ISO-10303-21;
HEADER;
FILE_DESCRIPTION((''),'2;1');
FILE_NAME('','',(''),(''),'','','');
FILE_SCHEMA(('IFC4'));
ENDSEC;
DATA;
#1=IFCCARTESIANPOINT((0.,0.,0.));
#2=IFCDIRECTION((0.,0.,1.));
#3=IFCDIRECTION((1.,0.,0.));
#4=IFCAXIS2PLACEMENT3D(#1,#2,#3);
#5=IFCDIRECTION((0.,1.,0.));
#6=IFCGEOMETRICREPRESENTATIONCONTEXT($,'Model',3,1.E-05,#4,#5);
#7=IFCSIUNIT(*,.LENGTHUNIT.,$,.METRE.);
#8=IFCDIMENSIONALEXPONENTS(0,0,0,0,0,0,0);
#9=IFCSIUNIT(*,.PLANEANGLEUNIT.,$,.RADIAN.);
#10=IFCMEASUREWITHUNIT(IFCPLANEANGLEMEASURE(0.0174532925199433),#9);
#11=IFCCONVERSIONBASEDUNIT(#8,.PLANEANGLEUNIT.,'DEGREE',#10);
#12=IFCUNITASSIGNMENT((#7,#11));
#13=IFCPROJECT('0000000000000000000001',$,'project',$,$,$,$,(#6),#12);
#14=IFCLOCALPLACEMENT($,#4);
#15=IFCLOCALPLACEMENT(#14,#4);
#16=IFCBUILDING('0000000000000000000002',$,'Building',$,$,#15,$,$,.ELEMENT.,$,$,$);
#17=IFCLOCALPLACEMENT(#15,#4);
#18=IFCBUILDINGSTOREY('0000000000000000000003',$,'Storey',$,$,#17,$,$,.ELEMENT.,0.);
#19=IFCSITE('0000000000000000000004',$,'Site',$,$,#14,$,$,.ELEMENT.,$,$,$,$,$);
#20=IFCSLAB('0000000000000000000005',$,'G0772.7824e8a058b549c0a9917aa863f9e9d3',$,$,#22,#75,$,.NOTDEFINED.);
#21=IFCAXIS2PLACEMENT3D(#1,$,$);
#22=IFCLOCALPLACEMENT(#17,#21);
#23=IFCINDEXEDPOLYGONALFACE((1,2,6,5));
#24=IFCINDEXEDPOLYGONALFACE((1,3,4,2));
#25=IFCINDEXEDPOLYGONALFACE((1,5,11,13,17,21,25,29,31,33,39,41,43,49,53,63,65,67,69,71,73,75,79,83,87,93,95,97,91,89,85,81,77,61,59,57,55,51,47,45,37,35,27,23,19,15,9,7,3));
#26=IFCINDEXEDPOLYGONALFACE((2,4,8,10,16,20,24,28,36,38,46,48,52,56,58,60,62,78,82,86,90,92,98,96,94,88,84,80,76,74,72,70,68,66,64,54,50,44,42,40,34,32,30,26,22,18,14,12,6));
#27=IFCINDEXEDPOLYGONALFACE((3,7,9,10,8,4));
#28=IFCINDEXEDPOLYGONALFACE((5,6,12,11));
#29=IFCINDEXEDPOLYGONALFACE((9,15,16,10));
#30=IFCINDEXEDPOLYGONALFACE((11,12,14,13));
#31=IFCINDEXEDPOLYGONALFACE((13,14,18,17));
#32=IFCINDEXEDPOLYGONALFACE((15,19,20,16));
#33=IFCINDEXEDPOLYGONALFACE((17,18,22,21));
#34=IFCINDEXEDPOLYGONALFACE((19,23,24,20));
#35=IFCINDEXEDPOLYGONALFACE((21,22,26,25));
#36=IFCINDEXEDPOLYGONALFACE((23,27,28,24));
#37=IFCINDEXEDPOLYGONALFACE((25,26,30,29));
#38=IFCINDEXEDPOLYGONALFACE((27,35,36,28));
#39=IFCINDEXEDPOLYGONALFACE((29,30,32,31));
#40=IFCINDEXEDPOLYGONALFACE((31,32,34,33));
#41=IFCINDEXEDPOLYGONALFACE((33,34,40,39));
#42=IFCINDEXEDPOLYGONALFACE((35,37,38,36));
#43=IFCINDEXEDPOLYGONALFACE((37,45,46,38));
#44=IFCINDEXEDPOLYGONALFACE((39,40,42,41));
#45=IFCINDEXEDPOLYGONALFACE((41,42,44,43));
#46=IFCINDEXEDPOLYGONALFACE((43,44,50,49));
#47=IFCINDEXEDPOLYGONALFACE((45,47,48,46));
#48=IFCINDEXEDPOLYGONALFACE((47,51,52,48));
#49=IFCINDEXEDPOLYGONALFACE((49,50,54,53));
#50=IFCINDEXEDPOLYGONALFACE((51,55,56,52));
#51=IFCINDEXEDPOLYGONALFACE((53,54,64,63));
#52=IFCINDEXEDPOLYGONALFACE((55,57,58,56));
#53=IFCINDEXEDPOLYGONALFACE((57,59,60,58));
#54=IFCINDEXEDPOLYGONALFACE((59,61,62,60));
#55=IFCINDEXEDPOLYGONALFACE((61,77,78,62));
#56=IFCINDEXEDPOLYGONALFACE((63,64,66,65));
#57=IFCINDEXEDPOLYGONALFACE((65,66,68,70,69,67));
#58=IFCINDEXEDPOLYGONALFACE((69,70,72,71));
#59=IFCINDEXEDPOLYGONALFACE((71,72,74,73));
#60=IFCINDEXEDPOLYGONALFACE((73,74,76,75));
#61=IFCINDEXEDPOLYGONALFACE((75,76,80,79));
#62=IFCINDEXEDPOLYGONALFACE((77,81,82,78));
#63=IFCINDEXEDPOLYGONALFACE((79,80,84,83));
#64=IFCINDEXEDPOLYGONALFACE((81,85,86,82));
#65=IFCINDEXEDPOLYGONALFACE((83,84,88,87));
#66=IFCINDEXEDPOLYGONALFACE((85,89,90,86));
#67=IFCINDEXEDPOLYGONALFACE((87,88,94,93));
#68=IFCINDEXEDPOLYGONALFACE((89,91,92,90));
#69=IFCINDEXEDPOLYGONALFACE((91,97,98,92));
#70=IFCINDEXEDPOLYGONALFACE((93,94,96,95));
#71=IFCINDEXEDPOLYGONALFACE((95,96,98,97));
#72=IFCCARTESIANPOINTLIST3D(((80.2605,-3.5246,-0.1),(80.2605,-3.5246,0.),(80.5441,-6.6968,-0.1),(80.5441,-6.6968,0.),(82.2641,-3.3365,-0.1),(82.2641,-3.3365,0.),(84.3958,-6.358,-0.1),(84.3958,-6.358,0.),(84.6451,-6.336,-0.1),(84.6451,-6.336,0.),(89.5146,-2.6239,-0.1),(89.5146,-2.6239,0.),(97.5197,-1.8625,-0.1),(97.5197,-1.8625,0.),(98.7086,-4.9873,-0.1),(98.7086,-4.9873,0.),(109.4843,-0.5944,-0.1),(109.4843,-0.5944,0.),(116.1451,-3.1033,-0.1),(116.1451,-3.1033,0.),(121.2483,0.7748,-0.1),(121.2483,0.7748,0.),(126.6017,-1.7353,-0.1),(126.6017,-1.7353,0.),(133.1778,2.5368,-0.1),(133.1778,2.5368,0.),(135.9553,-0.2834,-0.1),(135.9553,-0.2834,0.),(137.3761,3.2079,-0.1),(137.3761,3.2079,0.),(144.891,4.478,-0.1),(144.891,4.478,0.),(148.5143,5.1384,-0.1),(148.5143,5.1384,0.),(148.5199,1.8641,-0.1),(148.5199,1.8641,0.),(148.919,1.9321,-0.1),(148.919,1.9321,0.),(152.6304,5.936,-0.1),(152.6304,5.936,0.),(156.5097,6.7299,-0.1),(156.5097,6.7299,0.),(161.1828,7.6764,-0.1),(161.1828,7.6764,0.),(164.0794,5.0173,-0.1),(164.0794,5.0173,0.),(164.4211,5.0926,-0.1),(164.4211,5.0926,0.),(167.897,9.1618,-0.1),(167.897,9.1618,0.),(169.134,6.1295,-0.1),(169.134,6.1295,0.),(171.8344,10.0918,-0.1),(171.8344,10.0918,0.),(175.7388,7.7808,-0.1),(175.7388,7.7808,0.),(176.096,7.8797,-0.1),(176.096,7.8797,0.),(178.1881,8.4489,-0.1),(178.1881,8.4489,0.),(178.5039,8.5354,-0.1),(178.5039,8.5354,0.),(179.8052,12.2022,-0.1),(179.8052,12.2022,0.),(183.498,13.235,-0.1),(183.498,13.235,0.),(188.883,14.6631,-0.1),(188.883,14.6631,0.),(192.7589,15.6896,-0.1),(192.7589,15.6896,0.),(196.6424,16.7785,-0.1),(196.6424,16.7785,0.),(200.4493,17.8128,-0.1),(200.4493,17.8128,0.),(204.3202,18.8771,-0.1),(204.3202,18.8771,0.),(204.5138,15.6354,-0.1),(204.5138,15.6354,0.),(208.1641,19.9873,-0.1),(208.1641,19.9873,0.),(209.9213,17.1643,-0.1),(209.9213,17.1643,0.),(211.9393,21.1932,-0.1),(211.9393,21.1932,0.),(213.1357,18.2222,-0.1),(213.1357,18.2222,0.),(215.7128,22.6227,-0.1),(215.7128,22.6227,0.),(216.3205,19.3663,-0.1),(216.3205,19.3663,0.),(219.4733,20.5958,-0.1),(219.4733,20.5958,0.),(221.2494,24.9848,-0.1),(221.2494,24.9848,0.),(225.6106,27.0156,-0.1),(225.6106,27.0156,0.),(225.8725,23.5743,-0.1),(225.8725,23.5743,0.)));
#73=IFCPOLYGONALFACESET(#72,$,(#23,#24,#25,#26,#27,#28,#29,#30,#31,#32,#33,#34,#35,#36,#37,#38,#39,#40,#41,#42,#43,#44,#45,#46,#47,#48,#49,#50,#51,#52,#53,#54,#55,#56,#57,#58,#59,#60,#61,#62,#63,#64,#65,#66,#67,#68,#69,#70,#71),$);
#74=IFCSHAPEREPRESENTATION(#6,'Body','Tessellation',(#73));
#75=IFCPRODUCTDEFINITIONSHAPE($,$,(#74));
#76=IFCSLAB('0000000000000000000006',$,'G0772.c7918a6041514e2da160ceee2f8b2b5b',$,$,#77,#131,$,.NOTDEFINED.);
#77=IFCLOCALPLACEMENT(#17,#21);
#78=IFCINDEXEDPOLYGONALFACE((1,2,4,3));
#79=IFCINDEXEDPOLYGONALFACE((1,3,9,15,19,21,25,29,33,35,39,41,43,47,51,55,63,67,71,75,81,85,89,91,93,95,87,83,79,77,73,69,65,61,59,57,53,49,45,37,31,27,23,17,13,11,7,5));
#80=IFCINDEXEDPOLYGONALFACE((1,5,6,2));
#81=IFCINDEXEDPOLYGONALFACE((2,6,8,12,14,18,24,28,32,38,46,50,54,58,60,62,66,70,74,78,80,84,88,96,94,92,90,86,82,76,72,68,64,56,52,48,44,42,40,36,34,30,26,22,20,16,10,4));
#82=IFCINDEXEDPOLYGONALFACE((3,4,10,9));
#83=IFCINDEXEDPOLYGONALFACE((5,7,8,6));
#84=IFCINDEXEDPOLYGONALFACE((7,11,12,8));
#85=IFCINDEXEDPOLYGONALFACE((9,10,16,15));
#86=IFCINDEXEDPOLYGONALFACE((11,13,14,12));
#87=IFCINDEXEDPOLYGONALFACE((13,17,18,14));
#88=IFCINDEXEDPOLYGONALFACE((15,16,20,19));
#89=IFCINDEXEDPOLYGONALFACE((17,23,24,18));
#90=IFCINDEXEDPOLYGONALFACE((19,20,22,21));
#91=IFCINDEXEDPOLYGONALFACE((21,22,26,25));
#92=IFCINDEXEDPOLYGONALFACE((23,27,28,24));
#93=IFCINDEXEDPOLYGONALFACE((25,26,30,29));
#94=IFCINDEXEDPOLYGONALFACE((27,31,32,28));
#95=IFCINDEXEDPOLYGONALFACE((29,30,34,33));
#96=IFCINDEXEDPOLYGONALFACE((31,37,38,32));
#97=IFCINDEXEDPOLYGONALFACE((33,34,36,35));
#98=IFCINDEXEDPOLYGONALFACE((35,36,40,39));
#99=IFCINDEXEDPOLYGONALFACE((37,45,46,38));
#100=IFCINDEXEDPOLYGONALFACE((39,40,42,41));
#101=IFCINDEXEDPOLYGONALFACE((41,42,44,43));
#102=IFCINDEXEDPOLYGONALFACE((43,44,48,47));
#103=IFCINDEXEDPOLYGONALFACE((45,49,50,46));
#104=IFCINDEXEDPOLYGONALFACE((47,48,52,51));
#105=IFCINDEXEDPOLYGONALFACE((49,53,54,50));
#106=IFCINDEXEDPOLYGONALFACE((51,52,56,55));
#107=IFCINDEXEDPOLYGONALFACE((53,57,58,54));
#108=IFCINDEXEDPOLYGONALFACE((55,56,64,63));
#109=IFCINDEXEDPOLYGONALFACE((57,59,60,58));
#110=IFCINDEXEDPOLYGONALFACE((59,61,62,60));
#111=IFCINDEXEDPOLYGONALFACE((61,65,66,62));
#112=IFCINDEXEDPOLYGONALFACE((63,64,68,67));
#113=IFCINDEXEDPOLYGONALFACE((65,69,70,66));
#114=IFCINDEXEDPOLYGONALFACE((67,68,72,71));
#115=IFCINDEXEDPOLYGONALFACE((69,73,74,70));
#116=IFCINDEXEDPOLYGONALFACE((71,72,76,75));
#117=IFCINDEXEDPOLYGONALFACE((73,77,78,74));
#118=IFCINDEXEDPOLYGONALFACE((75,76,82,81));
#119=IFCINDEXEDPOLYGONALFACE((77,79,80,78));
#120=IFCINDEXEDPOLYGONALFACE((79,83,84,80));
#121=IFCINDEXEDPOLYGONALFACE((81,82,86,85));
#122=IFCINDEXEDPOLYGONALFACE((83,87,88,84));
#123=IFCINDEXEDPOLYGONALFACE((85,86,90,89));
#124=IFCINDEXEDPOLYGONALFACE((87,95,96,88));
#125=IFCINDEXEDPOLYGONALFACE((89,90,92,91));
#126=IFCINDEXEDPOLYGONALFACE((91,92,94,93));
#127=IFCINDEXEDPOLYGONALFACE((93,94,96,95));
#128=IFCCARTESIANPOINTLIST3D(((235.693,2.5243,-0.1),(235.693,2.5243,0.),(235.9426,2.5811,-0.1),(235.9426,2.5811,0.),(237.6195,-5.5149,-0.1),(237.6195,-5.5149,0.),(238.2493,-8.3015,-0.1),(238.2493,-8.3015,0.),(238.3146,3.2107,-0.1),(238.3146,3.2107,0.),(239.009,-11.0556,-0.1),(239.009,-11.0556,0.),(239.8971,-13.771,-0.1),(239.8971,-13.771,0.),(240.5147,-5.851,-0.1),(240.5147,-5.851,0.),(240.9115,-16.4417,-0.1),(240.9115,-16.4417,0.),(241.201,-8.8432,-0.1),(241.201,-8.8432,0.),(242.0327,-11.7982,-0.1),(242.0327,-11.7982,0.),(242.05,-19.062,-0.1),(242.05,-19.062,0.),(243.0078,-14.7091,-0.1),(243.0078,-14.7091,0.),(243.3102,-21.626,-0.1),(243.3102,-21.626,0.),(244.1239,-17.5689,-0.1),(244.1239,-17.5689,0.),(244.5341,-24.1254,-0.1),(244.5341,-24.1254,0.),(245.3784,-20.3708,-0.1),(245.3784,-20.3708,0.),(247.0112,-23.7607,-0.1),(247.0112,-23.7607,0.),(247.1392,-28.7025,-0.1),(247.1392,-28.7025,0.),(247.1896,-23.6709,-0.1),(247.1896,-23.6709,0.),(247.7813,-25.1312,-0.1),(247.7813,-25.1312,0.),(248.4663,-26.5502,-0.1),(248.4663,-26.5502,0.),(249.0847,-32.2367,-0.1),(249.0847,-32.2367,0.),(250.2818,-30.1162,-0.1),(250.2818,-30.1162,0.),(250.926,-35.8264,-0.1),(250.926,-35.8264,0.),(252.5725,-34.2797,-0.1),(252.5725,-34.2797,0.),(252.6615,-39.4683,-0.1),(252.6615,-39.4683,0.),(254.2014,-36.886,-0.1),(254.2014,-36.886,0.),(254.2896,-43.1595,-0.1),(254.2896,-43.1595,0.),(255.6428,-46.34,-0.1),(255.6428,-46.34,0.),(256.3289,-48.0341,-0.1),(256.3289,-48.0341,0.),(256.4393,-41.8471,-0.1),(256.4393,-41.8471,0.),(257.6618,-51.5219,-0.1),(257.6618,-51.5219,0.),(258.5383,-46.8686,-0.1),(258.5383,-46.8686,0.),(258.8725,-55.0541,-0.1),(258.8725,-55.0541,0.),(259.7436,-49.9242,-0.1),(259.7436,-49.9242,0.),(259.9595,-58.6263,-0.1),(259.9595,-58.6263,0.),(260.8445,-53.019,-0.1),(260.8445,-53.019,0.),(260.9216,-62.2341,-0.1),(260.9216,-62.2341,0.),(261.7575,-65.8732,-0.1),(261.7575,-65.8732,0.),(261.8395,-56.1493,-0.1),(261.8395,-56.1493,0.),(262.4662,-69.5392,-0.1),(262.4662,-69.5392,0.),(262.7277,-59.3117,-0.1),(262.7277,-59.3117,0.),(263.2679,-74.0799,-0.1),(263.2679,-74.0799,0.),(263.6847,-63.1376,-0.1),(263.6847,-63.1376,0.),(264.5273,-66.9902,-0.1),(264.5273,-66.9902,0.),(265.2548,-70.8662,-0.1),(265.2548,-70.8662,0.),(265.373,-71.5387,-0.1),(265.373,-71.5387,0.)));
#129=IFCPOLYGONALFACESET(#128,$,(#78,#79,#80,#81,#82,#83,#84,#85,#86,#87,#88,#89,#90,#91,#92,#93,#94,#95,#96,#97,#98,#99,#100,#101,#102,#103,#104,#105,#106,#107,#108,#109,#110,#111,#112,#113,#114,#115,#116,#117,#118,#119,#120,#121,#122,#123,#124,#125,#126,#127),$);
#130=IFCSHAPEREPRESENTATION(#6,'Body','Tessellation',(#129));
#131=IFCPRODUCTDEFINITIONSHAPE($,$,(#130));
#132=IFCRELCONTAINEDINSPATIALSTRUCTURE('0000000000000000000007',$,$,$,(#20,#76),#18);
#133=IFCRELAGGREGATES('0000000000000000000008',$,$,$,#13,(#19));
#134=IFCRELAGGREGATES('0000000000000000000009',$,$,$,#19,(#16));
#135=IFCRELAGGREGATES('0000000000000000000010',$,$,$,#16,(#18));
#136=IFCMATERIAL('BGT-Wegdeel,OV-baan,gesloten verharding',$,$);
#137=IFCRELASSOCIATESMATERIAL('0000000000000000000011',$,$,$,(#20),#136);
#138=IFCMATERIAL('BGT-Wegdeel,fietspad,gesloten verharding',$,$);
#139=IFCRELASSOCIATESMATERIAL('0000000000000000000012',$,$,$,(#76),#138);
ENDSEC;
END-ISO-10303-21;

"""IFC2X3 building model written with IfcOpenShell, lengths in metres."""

from ifc_helpers import new_model, entity, si_unit, converted_unit, direction, frame, origin_with_axes, place, context, project, spatial, polyline, outline, extrude, material, element, save


model = new_model("IFC2X3")

# Units and contexts
model_context = context("Model", 3, precision=1e-05, world=origin_with_axes(), true_north=direction((0.0, 1.0, 0.0)))
ifc_project = project(units=[si_unit("LENGTHUNIT", "METRE"), converted_unit("PLANEANGLEUNIT", "DEGREE", entity("IfcPlaneAngleMeasure", 0.0174532925199433), si_unit("PLANEANGLEUNIT", "RADIAN"), dimensions=[0, 0, 0, 0, 0, 0, 0])], contexts=[model_context])

# Site, building, storey
site_placement = place(None, origin_with_axes())
site = spatial("IfcSite", under=ifc_project, at=site_placement, Name="Site", CompositionType="ELEMENT")
building_placement = place(site_placement, origin_with_axes())
building = spatial("IfcBuilding", under=site, at=building_placement, Name="Building", CompositionType="ELEMENT")
storey_placement = place(building_placement, origin_with_axes())
storey = spatial("IfcBuildingStorey", under=building, at=storey_placement, Name="Storey", CompositionType="ELEMENT", Elevation=0.0)

# Slabs
ifc_material_1 = material(Name="BGT-Wegdeel,OV-baan,gesloten verharding")
slab_1_placement = place(storey_placement, frame((0.0, 0.0, -0.1), z_axis=(0.0, 0.0, 1.0), x_axis=(1.0, 0.0, 0.0)))
element("IfcSlab", 1, at=slab_1_placement, inside=storey, material=ifc_material_1, Name="G0772.7824e8a058b549c0a9917aa863f9e9d3", PredefinedType="NOTDEFINED", context=model_context, shape_type="SweptSolid", body=[
    extrude(outline(polyline([(121.2483, 0.7748), (133.1778, 2.5368), (137.3761, 3.2079), (144.891, 4.478), (148.5143, 5.1384), (152.6304, 5.936), (156.5097, 6.7299), (161.1828, 7.6764), (167.897, 9.1618), (171.8344, 10.0918), (179.8052, 12.2022), (183.498, 13.235), (188.883, 14.6631), (192.7589, 15.6896), (196.6424, 16.7785), (200.4493, 17.8128), (204.3202, 18.8771), (208.1641, 19.9873), (211.9393, 21.1932), (215.7128, 22.6227), (221.2494, 24.9848), (225.6106, 27.0156), (225.8725, 23.5743), (219.4733, 20.5958), (216.3205, 19.3663), (213.1357, 18.2222), (209.9213, 17.1643), (204.5138, 15.6354), (178.5039, 8.5354), (178.1881, 8.4489), (176.096, 7.8797), (175.7388, 7.7808), (169.134, 6.1295), (164.4211, 5.0926), (164.0794, 5.0173), (148.919, 1.9321), (148.5199, 1.8641), (135.9553, -0.2834), (126.6017, -1.7353), (116.1451, -3.1033), (98.7086, -4.9873), (84.6451, -6.336), (84.3958, -6.358), (80.5441, -6.6968), (80.2605, -3.5246), (82.2641, -3.3365), (89.5146, -2.6239), (97.5197, -1.8625), (109.4843, -0.5944), (121.2483, 0.7748)])), origin_with_axes(), (0.0, 0.0, 1.0), 0.1),
])
ifc_material_2 = material(Name="BGT-Wegdeel,fietspad,gesloten verharding")
slab_2_placement = place(storey_placement, frame((0.0, 0.0, -0.1), z_axis=(0.0, 0.0, 1.0), x_axis=(1.0, 0.0, 0.0)))
element("IfcSlab", 2, at=slab_2_placement, inside=storey, material=ifc_material_2, Name="G0772.c7918a6041514e2da160ceee2f8b2b5b", PredefinedType="NOTDEFINED", context=model_context, shape_type="SweptSolid", body=[
    extrude(outline(polyline([(262.4662, -69.5392), (261.7575, -65.8732), (260.9216, -62.2341), (259.9595, -58.6263), (258.8725, -55.0541), (257.6618, -51.5219), (256.3289, -48.0341), (255.6428, -46.34), (254.2896, -43.1595), (252.6615, -39.4683), (250.926, -35.8264), (249.0847, -32.2367), (247.1392, -28.7025), (244.5341, -24.1254), (243.3102, -21.626), (242.05, -19.062), (240.9115, -16.4417), (239.8971, -13.771), (239.009, -11.0556), (238.2493, -8.3015), (237.6195, -5.5149), (235.693, 2.5243), (235.9426, 2.5811), (238.3146, 3.2107), (240.5147, -5.851), (241.201, -8.8432), (242.0327, -11.7982), (243.0078, -14.7091), (244.1239, -17.5689), (245.3784, -20.3708), (247.0112, -23.7607), (247.1896, -23.6709), (247.7813, -25.1312), (248.4663, -26.5502), (250.2818, -30.1162), (252.5725, -34.2797), (254.2014, -36.886), (256.4393, -41.8471), (258.5383, -46.8686), (259.7436, -49.9242), (260.8445, -53.019), (261.8395, -56.1493), (262.7277, -59.3117), (263.6847, -63.1376), (264.5273, -66.9902), (265.2548, -70.8662), (265.373, -71.5387), (263.2679, -74.0799), (262.4662, -69.5392)])), origin_with_axes(), (0.0, 0.0, 1.0), 0.1),
])

save(model, "model.ifc")
